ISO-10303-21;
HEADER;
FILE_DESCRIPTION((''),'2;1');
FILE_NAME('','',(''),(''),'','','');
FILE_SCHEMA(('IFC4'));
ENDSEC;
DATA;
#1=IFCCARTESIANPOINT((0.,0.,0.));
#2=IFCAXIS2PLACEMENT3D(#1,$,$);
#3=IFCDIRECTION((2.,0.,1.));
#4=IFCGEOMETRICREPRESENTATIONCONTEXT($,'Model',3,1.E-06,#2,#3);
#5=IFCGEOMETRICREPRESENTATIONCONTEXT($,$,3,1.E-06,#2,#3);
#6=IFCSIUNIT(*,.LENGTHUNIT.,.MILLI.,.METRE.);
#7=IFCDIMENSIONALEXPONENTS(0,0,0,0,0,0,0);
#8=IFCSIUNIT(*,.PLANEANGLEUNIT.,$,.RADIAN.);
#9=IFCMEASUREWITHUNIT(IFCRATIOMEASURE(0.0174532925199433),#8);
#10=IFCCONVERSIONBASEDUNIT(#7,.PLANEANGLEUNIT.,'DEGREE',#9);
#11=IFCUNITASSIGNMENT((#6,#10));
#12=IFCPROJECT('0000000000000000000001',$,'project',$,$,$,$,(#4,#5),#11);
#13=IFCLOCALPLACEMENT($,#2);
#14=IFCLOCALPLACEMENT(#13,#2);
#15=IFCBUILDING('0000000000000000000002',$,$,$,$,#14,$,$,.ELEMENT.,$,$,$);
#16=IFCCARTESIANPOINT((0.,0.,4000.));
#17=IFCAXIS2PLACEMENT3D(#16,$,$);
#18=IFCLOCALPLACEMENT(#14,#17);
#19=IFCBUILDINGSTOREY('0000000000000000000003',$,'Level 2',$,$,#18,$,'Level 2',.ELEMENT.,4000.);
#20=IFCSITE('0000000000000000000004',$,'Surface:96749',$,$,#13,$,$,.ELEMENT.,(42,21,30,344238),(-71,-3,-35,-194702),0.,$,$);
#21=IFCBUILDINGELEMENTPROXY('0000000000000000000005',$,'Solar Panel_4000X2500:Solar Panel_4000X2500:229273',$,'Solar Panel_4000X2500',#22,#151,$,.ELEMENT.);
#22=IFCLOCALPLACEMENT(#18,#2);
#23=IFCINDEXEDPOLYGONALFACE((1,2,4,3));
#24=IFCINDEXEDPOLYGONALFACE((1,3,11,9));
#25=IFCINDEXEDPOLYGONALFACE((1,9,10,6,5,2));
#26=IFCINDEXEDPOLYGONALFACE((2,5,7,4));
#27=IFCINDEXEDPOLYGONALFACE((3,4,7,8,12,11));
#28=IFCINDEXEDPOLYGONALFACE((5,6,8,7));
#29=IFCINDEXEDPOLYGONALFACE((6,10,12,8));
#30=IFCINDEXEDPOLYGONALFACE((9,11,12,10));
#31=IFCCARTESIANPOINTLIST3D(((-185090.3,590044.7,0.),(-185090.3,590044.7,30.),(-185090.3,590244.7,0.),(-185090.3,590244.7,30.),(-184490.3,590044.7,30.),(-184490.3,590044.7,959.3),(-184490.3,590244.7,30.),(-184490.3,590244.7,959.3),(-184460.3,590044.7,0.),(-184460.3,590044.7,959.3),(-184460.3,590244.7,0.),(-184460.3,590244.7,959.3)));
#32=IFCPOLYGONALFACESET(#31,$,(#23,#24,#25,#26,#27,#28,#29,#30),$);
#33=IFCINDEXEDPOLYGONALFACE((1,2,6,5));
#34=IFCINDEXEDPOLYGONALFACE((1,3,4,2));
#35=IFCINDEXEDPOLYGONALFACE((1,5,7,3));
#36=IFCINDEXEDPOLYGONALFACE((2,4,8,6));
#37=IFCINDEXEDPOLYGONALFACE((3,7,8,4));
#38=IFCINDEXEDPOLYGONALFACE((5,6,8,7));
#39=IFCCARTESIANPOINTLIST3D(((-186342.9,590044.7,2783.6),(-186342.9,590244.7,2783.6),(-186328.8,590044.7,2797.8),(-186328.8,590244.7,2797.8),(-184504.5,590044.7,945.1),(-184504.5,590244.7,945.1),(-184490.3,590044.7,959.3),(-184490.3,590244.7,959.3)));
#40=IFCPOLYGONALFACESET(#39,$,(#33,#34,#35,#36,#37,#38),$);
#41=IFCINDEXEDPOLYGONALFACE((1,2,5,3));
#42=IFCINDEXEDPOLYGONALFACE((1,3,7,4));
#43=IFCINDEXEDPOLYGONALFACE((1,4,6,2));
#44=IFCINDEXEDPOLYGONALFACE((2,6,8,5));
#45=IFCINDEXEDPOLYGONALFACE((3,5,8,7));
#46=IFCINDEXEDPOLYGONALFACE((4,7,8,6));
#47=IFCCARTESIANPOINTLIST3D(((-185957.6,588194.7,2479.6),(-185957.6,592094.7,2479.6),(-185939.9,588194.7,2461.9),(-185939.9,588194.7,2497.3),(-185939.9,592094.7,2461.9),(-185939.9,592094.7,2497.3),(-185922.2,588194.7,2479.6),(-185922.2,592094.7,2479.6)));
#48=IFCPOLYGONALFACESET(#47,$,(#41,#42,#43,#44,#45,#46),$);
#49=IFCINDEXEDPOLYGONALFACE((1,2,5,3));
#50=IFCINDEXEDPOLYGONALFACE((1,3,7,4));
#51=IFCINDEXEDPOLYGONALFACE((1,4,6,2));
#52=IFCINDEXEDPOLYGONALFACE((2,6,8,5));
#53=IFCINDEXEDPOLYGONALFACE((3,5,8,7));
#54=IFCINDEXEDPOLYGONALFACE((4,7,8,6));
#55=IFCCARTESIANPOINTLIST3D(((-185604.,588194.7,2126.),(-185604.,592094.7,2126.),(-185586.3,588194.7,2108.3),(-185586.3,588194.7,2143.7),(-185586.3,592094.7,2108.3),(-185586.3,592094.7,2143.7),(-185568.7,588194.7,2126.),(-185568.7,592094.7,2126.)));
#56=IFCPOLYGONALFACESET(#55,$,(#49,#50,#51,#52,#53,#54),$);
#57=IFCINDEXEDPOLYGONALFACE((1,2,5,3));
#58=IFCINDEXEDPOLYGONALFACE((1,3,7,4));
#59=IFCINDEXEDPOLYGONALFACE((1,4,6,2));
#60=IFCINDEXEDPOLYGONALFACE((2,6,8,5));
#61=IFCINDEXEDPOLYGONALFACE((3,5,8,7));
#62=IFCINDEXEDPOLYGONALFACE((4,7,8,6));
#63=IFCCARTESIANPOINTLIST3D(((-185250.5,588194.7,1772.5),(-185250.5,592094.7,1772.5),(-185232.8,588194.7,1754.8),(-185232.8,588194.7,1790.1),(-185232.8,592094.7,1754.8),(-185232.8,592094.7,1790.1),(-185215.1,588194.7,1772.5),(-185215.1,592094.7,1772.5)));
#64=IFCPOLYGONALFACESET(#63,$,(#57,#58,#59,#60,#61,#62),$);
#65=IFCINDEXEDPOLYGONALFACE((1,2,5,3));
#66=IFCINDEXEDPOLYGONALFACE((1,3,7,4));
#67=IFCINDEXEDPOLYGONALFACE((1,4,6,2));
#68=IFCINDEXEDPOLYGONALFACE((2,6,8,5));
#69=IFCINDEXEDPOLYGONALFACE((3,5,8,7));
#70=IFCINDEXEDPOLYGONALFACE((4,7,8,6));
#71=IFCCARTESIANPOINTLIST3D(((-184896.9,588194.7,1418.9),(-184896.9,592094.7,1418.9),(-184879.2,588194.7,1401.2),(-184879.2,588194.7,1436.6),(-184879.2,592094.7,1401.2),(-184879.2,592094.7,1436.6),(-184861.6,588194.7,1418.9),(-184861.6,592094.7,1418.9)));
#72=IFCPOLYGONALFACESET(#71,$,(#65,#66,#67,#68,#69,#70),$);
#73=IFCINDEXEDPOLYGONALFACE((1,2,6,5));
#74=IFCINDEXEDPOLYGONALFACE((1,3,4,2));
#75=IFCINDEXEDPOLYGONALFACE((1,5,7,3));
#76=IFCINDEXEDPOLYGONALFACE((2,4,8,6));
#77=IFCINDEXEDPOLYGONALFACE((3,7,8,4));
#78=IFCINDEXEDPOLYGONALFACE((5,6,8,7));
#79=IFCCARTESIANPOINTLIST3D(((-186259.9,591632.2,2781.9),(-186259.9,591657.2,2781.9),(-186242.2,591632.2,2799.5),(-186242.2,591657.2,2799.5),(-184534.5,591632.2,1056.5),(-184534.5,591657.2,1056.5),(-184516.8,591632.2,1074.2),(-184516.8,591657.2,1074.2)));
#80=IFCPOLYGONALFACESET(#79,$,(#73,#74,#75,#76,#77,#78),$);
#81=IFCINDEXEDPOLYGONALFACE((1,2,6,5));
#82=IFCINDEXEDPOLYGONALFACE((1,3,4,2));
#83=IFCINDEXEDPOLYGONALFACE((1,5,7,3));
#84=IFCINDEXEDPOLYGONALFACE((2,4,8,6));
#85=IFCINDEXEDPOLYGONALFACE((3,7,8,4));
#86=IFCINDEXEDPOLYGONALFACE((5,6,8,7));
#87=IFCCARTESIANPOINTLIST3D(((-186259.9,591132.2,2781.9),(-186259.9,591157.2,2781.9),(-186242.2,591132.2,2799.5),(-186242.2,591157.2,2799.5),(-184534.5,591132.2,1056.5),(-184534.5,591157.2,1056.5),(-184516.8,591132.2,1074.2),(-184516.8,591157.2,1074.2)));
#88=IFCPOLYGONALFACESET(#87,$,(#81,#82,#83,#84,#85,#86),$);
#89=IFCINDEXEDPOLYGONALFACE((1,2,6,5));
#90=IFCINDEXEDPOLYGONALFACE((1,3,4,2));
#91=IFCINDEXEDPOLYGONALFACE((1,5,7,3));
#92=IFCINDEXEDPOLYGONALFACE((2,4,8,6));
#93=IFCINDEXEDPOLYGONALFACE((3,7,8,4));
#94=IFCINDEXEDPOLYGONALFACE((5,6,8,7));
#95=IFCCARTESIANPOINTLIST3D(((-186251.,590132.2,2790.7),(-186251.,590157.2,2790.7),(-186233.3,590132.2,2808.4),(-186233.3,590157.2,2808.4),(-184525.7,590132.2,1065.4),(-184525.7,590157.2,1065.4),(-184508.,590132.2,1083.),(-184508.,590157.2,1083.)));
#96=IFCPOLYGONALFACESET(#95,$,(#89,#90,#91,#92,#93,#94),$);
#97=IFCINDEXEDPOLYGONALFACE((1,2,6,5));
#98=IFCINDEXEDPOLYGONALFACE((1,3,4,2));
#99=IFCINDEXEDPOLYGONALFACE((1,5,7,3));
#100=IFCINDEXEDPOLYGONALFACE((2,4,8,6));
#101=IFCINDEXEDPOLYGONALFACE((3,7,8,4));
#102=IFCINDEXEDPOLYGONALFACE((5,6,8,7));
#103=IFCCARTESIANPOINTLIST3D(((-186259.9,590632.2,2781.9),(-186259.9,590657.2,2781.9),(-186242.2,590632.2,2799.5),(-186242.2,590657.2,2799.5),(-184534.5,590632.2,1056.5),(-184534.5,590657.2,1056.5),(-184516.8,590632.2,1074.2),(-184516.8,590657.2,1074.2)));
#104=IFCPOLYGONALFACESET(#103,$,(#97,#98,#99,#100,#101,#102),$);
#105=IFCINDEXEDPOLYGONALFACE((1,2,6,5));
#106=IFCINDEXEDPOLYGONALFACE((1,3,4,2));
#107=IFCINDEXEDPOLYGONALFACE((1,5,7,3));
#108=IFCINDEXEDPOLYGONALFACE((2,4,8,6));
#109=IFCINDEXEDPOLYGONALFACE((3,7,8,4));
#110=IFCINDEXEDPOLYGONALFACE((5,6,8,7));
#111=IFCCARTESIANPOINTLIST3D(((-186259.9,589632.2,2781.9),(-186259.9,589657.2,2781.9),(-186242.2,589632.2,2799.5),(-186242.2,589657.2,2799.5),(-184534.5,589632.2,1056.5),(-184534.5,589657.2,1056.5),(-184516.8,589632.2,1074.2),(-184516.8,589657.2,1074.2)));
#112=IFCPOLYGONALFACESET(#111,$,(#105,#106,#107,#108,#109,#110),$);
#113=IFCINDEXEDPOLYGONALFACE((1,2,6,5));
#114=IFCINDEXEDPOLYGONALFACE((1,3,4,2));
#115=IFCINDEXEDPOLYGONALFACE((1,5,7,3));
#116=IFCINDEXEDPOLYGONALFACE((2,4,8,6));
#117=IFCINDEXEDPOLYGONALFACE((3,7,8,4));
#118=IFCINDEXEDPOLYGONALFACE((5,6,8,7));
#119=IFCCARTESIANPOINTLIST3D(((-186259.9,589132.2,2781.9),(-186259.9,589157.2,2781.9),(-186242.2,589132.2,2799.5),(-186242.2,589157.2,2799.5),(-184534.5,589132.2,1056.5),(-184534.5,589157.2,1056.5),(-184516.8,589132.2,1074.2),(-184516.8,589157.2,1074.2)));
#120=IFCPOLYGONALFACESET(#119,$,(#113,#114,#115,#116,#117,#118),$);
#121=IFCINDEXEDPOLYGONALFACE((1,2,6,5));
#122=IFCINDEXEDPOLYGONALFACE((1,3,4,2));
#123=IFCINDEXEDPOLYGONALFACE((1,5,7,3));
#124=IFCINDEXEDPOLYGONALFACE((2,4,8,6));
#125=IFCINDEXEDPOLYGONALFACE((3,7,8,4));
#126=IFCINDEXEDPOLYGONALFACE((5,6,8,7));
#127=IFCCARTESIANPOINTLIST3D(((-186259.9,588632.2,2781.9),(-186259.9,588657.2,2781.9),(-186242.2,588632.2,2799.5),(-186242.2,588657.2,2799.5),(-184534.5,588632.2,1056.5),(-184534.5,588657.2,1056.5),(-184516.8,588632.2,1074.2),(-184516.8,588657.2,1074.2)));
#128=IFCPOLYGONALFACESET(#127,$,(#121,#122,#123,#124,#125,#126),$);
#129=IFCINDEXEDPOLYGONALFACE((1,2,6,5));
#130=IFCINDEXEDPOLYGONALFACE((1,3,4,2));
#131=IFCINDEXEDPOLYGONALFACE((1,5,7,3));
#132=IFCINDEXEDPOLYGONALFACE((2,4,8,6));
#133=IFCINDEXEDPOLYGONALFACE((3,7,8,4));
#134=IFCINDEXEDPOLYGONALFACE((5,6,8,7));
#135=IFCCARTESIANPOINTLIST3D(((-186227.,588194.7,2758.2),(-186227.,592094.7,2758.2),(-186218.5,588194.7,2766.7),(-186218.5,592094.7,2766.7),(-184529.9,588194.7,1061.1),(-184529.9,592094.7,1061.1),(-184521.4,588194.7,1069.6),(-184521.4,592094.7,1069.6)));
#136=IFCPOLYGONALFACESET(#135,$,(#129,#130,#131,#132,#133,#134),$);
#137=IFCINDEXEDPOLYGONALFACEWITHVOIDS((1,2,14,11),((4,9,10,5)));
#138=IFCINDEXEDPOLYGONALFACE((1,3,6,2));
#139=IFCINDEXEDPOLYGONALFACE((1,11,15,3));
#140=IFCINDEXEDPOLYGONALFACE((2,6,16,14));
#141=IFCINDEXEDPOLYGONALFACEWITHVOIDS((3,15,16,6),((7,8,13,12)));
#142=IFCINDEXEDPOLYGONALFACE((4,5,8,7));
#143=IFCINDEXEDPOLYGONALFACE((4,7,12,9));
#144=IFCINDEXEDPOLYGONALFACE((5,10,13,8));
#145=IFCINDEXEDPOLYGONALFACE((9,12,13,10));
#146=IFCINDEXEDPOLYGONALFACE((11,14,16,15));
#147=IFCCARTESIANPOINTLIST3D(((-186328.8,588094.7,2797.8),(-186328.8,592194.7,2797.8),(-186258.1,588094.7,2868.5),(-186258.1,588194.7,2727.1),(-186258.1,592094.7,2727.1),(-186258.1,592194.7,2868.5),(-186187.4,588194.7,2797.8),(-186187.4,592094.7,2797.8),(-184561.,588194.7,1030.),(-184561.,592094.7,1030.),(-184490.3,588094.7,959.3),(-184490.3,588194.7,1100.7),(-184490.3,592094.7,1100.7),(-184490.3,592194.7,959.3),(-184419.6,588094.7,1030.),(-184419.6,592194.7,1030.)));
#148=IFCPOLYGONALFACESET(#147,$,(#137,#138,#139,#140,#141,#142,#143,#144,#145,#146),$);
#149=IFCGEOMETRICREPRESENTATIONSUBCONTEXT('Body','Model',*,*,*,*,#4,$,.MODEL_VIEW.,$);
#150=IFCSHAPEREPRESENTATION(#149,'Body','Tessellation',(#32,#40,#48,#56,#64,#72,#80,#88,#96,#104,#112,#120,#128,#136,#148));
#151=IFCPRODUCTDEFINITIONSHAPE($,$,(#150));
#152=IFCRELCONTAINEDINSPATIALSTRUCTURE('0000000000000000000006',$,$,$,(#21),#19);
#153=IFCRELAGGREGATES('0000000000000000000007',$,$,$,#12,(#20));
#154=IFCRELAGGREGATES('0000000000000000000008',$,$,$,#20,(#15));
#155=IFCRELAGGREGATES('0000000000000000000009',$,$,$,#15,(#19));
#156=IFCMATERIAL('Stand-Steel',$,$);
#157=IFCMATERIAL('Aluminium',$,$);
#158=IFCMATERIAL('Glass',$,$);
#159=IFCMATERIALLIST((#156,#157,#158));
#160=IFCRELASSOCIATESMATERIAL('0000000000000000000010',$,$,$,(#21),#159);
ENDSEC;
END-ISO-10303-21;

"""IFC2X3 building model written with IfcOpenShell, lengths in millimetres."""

from ifc_helpers import new_model, entity, si_unit, converted_unit, direction, frame, frame_2d, origin, origin_2d_with_axis, place, context, subcontext, project, spatial, polyline, rectangle, outline, extrude, source, transform, mapped, material, material_list, element, save


model = new_model("IFC2X3")

# Units and contexts
model_context = context("Model", 3, precision=1e-06, world=origin(), true_north=direction((2.0, 0.0, 1.0)))
context_of_model = context(None, 3, precision=1e-06, world=origin(), true_north=direction((2.0, 0.0, 1.0)))
body_context = subcontext(model_context, "Body", "Model", "MODEL_VIEW")
ifc_project = project(units=[si_unit("LENGTHUNIT", "METRE", prefix="MILLI"), converted_unit("PLANEANGLEUNIT", "DEGREE", entity("IfcRatioMeasure", 0.0174532925199433), si_unit("PLANEANGLEUNIT", "RADIAN"), dimensions=[0, 0, 0, 0, 0, 0, 0])], contexts=[model_context, context_of_model])

# Site, building, storey
site_placement = place(None, origin())
site = spatial("IfcSite", under=ifc_project, at=site_placement, Name="Surface:96749", CompositionType="ELEMENT", RefLatitude=(42, 21, 30, 344238), RefLongitude=(-71, -3, -35, -194702), RefElevation=0.0)
building_placement = place(site_placement, origin())
building = spatial("IfcBuilding", under=site, at=building_placement, CompositionType="ELEMENT")
storey_placement = place(building_placement, frame((0.0, 0.0, 4000.0)))
storey = spatial("IfcBuildingStorey", under=building, at=storey_placement, Name="Level 2", LongName="Level 2", CompositionType="ELEMENT", Elevation=4000.0)

# Building element proxy
ifc_material_1 = material(Name="Stand-Steel")
ifc_material_2 = material(Name="Aluminium")
ifc_material_3 = material(Name="Glass")
shared_shape = source(origin(), body_context, "Body", "SweptSolid", [
    extrude(outline(polyline([(-629.5, -220.0), (329.8, -220.0), (329.8, 410.0), (299.8, 410.0), (299.8, -190.0), (-629.5, -190.0), (-629.5, -220.0)])), frame((-190.0, -100.0, 299.8), z_axis=(0.0, 1.0, 0.0), x_axis=(0.0, 0.0, -1.0)), (0.0, 0.0, 1.0), 200.0),
    extrude(rectangle(XDim=20.0, YDim=200.0, at=frame_2d((0.0, 0.0), x_axis=(0.0, 1.0))), frame((-7.1, 0.0, 922.2), z_axis=(-0.707107, 0.0, 0.707107), x_axis=(0.0, 1.0, 0.0)), (0.0, 0.0, 1.0), 2600.0),
    extrude(rectangle(XDim=25.0, YDim=25.0, at=frame_2d((0.0, 0.0), x_axis=(1.0, 0.0))), frame((-1449.6, -1950.0, 2449.6), z_axis=(0.0, 1.0, 0.0), x_axis=(-0.707107, 0.0, -0.707107)), (0.0, 0.0, 1.0), 3900.0),
    extrude(rectangle(XDim=25.0, YDim=25.0, at=origin_2d_with_axis()), frame((-1096.0, -1950.0, 2096.0), z_axis=(0.0, 1.0, 0.0), x_axis=(-0.707107, 0.0, -0.707107)), (0.0, 0.0, 1.0), 3900.0),
    extrude(rectangle(XDim=25.0, YDim=25.0, at=origin_2d_with_axis()), frame((-742.5, -1950.0, 1742.5), z_axis=(0.0, 1.0, 0.0), x_axis=(-0.707107, 0.0, -0.707107)), (0.0, 0.0, 1.0), 3900.0),
    extrude(rectangle(XDim=25.0, YDim=25.0, at=frame_2d((0.0, 0.0), x_axis=(1.0, 0.0))), frame((-388.9, -1950.0, 1388.9), z_axis=(0.0, 1.0, 0.0), x_axis=(-0.707107, 0.0, -0.707107)), (0.0, 0.0, 1.0), 3900.0),
    extrude(rectangle(XDim=25.0, YDim=25.0, at=frame_2d((0.0, 0.0), x_axis=(0.0, 1.0))), frame((-35.4, 1500.0, 1035.4), z_axis=(-0.707107, 0.0, 0.707107), x_axis=(0.0, 1.0, 0.0)), (0.0, 0.0, 1.0), 2440.0),
    extrude(rectangle(XDim=25.0, YDim=25.0, at=frame_2d((0.0, 0.0), x_axis=(0.0, 1.0))), frame((-35.4, 1000.0, 1035.4), z_axis=(-0.707107, 0.0, 0.707107), x_axis=(0.0, 1.0, 0.0)), (0.0, 0.0, 1.0), 2440.0),
    extrude(rectangle(XDim=25.0, YDim=25.0, at=frame_2d((0.0, 0.0), x_axis=(0.0, 1.0))), frame((-26.5, 0.0, 1044.2), z_axis=(-0.707107, 0.0, 0.707107), x_axis=(0.0, -1.0, 0.0)), (0.0, 0.0, 1.0), 2440.0),
    extrude(rectangle(XDim=25.0, YDim=25.0, at=frame_2d((0.0, 0.0), x_axis=(0.0, 1.0))), frame((-35.4, 500.0, 1035.4), z_axis=(-0.707107, 0.0, 0.707107), x_axis=(0.0, 1.0, 0.0)), (0.0, 0.0, 1.0), 2440.0),
    extrude(rectangle(XDim=25.0, YDim=25.0, at=frame_2d((0.0, 0.0), x_axis=(0.0, 1.0))), frame((-35.4, -500.0, 1035.4), z_axis=(-0.707107, 0.0, 0.707107), x_axis=(0.0, 1.0, 0.0)), (0.0, 0.0, 1.0), 2440.0),
    extrude(rectangle(XDim=25.0, YDim=25.0, at=frame_2d((0.0, 0.0), x_axis=(0.0, 1.0))), frame((-35.4, -1000.0, 1035.4), z_axis=(-0.707107, 0.0, 0.707107), x_axis=(0.0, 1.0, 0.0)), (0.0, 0.0, 1.0), 2440.0),
    extrude(rectangle(XDim=25.0, YDim=25.0, at=frame_2d((0.0, 0.0), x_axis=(0.0, 1.0))), frame((-35.4, -1500.0, 1035.4), z_axis=(-0.707107, 0.0, 0.707107), x_axis=(0.0, 1.0, 0.0)), (0.0, 0.0, 1.0), 2440.0),
    extrude(rectangle(XDim=2400.0, YDim=12.0, at=frame_2d((0.0, 0.0), x_axis=(1.0, 0.0))), frame((-883.9, -1950.0, 1883.9), z_axis=(0.0, 1.0, 0.0), x_axis=(0.707107, 0.0, -0.707107)), (0.0, 0.0, 1.0), 3900.0),
    extrude(outline(polyline([(-2050.0, -1300.0), (2050.0, -1300.0), (2050.0, 1300.0), (-2050.0, 1300.0), (-2050.0, -1300.0)]), holes=[polyline([(1950.0, -1200.0), (-1950.0, -1200.0), (-1950.0, 1200.0), (1950.0, 1200.0), (1950.0, -1200.0)])]), frame((-919.2, 0.0, 1848.5), z_axis=(0.707107, 0.0, 0.707107), x_axis=(0.0, 1.0, 0.0)), (0.0, 0.0, 1.0), 100.0),
])
ifc_material_list_1 = material_list([ifc_material_1, ifc_material_2, ifc_material_3])
proxy_1_placement = place(storey_placement, frame((-184490.3, 590144.7, 30.0)))
element("IfcBuildingElementProxy", 1, at=proxy_1_placement, inside=storey, material=ifc_material_list_1, Name="Solar Panel_4000X2500:Solar Panel_4000X2500:229273", ObjectType="Solar Panel_4000X2500", CompositionType="ELEMENT", context=body_context, shape_type="MappedRepresentation", body=[
    mapped(shared_shape, transform((0.0, 0.0, 0.0), scale=1.0)),
])

save(model, "model.ifc")
